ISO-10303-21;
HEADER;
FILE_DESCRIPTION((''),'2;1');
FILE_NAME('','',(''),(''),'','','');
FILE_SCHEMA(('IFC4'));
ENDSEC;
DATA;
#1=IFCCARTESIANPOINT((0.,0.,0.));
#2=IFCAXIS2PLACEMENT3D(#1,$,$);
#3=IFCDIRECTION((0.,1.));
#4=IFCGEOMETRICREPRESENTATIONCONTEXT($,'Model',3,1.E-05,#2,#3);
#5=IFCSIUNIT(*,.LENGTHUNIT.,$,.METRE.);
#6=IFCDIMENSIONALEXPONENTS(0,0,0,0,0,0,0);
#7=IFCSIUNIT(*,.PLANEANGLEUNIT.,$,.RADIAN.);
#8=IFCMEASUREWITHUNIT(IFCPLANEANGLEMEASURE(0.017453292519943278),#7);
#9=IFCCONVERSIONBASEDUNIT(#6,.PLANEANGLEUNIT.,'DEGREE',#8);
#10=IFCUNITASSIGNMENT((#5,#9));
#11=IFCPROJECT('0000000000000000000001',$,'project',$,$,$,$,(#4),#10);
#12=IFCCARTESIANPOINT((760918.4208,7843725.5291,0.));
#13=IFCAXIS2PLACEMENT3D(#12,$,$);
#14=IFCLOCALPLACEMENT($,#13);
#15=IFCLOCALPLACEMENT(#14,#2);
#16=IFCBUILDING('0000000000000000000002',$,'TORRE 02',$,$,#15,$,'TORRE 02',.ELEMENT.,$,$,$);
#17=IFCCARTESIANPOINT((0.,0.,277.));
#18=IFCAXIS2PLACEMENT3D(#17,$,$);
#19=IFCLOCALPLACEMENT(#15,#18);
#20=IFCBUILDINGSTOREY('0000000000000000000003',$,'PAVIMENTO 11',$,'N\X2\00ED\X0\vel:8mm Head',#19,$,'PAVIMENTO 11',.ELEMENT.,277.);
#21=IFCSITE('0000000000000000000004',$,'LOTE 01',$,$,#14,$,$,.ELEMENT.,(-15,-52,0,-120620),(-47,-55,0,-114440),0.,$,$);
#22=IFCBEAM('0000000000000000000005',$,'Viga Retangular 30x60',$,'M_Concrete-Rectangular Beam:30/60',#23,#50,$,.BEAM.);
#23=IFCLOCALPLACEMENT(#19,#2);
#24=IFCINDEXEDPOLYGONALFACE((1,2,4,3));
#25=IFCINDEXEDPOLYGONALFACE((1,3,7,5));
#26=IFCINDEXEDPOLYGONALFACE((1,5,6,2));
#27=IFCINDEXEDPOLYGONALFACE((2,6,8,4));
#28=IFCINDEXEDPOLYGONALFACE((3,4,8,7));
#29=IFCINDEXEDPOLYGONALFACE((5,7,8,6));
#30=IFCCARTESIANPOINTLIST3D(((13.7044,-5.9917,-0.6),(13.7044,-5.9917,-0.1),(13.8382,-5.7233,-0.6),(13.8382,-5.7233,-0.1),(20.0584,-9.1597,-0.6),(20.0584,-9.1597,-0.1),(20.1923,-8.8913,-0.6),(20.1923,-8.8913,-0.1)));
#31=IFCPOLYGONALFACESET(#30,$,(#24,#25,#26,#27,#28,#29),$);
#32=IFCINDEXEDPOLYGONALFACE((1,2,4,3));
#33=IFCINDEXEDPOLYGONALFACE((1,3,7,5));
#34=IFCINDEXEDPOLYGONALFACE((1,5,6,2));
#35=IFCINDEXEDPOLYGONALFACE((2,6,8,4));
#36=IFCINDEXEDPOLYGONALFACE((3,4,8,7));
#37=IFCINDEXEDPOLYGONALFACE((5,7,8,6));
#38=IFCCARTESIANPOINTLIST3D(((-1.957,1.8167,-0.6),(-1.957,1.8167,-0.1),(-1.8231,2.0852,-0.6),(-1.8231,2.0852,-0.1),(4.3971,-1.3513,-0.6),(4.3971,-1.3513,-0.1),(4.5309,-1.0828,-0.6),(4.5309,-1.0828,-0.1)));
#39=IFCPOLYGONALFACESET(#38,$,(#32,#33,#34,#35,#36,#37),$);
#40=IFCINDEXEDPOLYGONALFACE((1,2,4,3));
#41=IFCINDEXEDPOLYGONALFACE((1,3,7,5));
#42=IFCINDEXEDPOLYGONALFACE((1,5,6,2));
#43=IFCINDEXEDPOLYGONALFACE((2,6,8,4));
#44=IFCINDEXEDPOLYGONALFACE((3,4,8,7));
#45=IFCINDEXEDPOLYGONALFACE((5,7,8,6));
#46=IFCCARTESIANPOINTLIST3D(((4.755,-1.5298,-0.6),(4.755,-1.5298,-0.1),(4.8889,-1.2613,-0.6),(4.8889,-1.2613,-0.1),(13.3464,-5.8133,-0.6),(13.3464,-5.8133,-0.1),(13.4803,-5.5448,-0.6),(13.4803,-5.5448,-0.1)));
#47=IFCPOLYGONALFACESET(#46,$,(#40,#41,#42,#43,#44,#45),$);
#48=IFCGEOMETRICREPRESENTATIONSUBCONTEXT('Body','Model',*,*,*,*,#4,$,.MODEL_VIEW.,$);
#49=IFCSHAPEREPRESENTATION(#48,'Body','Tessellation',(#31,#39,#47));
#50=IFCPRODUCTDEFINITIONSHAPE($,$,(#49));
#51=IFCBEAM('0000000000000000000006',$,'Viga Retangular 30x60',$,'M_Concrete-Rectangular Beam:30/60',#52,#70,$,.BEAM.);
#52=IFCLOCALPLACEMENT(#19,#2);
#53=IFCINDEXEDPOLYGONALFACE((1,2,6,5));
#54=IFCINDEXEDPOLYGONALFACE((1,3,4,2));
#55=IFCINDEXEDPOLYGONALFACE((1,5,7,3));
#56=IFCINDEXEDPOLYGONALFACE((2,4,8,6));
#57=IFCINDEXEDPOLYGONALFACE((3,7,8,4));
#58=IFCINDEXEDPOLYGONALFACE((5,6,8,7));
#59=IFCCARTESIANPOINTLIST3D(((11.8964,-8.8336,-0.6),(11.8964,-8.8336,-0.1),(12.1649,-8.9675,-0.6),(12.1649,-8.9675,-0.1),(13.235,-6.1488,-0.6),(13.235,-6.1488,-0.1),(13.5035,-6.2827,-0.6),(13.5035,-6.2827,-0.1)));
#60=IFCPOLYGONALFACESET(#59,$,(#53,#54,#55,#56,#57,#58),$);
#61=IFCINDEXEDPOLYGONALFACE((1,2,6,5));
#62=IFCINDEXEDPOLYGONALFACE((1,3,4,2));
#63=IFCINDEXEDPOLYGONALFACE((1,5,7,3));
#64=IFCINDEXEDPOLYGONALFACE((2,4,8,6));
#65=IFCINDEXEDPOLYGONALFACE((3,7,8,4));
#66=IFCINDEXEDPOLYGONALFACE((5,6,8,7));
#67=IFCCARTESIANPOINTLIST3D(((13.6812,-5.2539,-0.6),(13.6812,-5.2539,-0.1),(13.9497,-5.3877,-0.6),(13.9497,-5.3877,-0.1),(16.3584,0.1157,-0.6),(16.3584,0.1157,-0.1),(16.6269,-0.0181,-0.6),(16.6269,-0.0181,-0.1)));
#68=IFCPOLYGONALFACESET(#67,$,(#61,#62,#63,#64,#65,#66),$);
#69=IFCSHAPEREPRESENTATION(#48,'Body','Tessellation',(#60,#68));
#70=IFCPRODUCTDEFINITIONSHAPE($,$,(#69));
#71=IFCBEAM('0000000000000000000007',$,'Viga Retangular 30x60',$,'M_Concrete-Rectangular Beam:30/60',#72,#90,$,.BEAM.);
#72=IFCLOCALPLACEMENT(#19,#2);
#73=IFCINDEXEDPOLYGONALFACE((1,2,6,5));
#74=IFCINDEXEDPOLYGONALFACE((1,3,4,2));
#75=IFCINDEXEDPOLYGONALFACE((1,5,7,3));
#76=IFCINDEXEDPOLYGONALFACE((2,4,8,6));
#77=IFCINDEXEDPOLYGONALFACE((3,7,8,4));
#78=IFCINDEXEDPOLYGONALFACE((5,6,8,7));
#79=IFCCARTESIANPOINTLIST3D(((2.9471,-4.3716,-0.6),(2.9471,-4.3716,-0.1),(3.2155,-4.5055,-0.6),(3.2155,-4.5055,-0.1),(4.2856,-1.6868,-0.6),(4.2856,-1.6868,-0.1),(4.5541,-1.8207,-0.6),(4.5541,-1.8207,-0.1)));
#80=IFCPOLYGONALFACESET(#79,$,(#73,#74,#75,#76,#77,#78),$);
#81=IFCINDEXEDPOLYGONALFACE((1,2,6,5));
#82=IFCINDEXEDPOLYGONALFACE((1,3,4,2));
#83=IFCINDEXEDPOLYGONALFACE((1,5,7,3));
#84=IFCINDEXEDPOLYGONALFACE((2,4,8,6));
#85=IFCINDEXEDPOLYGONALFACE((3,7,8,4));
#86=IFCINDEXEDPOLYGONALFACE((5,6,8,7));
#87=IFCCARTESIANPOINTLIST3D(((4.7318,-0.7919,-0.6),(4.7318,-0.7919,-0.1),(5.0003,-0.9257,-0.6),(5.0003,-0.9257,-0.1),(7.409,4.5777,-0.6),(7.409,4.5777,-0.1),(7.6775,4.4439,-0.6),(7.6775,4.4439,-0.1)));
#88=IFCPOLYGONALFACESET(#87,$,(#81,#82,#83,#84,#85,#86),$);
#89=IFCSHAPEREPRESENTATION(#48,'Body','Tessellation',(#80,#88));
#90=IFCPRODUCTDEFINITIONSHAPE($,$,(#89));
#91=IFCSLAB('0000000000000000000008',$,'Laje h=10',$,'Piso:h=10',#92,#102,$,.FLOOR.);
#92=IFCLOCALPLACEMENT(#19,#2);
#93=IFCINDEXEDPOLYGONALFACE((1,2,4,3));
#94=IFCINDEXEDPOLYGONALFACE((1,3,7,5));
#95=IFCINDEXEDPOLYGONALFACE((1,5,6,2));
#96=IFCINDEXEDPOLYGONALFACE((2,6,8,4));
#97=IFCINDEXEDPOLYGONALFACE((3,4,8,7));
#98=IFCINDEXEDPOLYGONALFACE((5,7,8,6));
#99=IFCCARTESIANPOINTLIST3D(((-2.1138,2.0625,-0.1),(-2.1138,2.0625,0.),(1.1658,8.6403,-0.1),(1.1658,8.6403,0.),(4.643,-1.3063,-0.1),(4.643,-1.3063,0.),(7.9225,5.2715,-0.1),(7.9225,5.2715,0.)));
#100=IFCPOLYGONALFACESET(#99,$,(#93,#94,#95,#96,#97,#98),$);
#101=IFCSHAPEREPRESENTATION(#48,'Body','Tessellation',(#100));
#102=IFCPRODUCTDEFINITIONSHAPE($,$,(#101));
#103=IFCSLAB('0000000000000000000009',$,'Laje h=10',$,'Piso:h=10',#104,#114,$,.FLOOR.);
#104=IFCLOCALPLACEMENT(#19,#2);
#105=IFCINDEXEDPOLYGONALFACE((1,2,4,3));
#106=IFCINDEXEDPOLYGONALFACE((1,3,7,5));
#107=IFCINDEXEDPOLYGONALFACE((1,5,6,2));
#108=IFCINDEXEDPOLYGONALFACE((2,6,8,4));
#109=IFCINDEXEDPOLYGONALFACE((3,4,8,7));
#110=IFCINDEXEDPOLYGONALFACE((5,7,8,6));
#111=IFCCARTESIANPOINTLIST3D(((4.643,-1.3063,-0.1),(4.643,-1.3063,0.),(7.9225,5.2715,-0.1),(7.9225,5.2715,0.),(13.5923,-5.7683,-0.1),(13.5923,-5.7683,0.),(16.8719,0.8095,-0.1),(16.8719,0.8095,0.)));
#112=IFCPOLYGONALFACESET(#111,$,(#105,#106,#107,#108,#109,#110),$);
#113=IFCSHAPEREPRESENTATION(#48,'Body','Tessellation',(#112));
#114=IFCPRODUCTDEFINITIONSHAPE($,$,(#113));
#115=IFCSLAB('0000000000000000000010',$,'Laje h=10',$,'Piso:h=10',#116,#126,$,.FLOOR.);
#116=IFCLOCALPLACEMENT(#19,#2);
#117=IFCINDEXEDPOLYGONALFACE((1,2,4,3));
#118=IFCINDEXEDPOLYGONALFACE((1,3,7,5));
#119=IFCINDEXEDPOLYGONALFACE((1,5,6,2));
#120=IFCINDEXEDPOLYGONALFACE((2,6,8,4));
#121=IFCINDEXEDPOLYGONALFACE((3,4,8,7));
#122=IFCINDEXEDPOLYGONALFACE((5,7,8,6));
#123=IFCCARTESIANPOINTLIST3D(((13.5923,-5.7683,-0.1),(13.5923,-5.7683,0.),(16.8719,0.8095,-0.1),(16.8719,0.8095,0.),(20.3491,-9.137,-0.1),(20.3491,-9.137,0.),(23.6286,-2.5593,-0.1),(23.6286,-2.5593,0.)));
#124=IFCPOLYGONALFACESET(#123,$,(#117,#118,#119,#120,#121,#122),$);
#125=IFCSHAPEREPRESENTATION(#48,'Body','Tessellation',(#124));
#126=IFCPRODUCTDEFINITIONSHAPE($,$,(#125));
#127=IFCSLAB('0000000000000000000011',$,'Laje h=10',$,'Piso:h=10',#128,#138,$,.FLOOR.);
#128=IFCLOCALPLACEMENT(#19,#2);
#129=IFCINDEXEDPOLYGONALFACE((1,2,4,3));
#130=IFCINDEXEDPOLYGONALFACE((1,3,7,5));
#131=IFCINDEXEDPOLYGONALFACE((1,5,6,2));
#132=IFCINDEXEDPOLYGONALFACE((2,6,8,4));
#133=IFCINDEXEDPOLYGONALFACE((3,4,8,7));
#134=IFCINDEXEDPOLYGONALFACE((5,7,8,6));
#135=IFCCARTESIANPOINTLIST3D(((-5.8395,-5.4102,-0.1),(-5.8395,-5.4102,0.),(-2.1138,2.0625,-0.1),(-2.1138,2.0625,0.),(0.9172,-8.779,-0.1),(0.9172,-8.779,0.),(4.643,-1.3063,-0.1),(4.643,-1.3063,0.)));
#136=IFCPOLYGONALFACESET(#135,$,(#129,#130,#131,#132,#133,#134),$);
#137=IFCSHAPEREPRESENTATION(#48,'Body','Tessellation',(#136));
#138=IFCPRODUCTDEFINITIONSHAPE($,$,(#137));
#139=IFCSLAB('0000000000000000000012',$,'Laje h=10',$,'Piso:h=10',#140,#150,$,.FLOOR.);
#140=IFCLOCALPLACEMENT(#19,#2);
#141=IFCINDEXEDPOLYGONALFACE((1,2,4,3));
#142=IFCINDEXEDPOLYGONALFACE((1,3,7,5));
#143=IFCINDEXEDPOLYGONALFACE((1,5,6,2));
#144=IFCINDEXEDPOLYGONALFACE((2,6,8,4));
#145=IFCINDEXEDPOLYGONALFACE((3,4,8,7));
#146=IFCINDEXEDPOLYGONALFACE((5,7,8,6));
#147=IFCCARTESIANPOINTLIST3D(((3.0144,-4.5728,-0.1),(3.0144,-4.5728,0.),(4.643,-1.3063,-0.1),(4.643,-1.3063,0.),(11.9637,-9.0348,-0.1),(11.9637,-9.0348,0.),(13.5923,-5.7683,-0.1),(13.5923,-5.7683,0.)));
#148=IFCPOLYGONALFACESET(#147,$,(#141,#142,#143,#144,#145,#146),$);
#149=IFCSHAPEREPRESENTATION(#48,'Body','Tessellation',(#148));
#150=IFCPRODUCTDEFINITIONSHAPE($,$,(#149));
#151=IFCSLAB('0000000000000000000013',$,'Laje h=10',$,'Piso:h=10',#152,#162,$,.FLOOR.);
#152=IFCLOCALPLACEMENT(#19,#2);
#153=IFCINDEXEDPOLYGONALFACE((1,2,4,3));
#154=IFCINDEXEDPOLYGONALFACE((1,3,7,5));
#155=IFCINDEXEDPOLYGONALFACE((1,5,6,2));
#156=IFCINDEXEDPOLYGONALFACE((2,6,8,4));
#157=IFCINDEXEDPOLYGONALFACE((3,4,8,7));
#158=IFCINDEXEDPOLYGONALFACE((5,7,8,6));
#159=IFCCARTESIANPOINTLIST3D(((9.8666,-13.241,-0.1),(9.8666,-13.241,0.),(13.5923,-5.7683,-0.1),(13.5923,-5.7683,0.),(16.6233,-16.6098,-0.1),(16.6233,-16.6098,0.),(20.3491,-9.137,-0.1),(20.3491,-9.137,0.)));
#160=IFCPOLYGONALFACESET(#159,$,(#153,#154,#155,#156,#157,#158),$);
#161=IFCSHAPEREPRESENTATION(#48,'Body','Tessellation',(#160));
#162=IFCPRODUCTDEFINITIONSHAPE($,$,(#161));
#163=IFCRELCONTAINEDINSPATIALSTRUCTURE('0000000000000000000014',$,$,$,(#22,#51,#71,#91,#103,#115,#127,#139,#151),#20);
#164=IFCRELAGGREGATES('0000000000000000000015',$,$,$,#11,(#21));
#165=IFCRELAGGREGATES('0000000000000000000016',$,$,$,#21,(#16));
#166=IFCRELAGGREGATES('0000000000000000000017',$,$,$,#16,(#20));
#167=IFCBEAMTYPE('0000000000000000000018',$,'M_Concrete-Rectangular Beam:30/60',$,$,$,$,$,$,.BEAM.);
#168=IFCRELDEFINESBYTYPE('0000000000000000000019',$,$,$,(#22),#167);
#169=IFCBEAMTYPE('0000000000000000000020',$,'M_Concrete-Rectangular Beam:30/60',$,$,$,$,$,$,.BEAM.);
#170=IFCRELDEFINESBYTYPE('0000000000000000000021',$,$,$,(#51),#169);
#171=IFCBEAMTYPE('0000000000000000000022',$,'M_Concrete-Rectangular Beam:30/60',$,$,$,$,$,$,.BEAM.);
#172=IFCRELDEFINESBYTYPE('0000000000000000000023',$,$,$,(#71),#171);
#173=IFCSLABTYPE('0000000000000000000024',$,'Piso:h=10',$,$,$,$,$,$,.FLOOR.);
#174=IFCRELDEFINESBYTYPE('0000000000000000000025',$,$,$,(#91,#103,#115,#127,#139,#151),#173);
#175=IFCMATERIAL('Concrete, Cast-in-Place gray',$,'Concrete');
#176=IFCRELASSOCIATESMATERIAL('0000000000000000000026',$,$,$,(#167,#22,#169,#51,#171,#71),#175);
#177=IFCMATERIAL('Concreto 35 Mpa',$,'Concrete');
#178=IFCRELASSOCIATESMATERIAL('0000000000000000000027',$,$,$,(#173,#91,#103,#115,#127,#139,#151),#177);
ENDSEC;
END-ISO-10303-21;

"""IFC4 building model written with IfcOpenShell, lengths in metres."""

from ifc_helpers import new_model, entity, si_unit, converted_unit, direction, frame, origin, place, context, subcontext, project, spatial, indexed_curve, outline, extrude, source, transform, mapped, material, type_object, type_shapes, element, save


model = new_model("IFC4")

# Units and contexts
model_context = context("Model", 3, precision=1e-05, world=origin(), true_north=direction((0.0, 1.0)))
body_context = subcontext(model_context, "Body", "Model", "MODEL_VIEW")
ifc_project = project(units=[si_unit("LENGTHUNIT", "METRE"), converted_unit("PLANEANGLEUNIT", "DEGREE", entity("IfcPlaneAngleMeasure", 0.017453292519943278), si_unit("PLANEANGLEUNIT", "RADIAN"), dimensions=[0, 0, 0, 0, 0, 0, 0])], contexts=[model_context])

# Site, building, storey
site_placement = place(None, frame((760918.4208, 7843725.5291, 0.0)))
site = spatial("IfcSite", under=ifc_project, at=site_placement, Name="LOTE 01", CompositionType="ELEMENT", RefLatitude=(-15, -52, 0, -120620), RefLongitude=(-47, -55, 0, -114440), RefElevation=0.0)
building_placement = place(site_placement, origin())
building = spatial("IfcBuilding", under=site, at=building_placement, Name="TORRE 02", LongName="TORRE 02", CompositionType="ELEMENT")
storey_placement = place(building_placement, frame((0.0, 0.0, 277.0)))
storey = spatial("IfcBuildingStorey", under=building, at=storey_placement, Name="PAVIMENTO 11", ObjectType="Nível:8mm Head", LongName="PAVIMENTO 11", CompositionType="ELEMENT", Elevation=277.0)

# Shared definitions
ifc_material_1 = material(Name="Concrete, Cast-in-Place gray", Category="Concrete")

# Beams
beam_type_1 = type_object("IfcBeamType", Name="M_Concrete-Rectangular Beam:30/60", PredefinedType="BEAM", material=ifc_material_1)
shared_shape_1 = source(origin(), body_context, "Body", "SweptSolid", [
    extrude(outline(indexed_curve([(-0.25, -0.15), (0.25, -0.15), (0.25, 0.15), (-0.25, 0.15), (-0.25, -0.15)], self_intersect=False)), frame((13.7713, -5.8575, 276.65), z_axis=(0.894934, -0.446198, 0.0), x_axis=(0.0, 0.0, -1.0)), (0.0, 0.0, 1.0), 7.1),
    extrude(outline(indexed_curve([(-0.25, -0.15), (0.25, -0.15), (0.25, 0.15), (-0.25, 0.15), (-0.25, -0.15)], self_intersect=False)), frame((-1.89, 1.951, 276.65), z_axis=(0.894934, -0.446198, 0.0), x_axis=(0.0, 0.0, -1.0)), (0.0, 0.0, 1.0), 7.1),
    extrude(outline(indexed_curve([(-0.25, -0.15), (0.25, -0.15), (0.25, 0.15), (-0.25, 0.15), (-0.25, -0.15)], self_intersect=False)), frame((4.822, -1.3955, 276.65), z_axis=(0.894934, -0.446198, 0.0), x_axis=(0.0, 0.0, -1.0)), (0.0, 0.0, 1.0), 9.6),
])
type_shapes(beam_type_1, [shared_shape_1])
beam_1_placement = place(storey_placement, frame((0.0, 0.0, -277.0)))
element("IfcBeam", 1, at=beam_1_placement, inside=storey, type_object=beam_type_1, material=ifc_material_1, Name="Viga Retangular 30x60", ObjectType="M_Concrete-Rectangular Beam:30/60", PredefinedType="BEAM", context=body_context, shape_type="MappedRepresentation", body=[
    mapped(shared_shape_1, transform((0.0, 0.0, 0.0), scale=1.0)),
])
beam_type_2 = type_object("IfcBeamType", Name="M_Concrete-Rectangular Beam:30/60", PredefinedType="BEAM", material=ifc_material_1)
shared_shape_2 = source(origin(), body_context, "Body", "SweptSolid", [
    extrude(outline(indexed_curve([(-0.25, -0.15), (0.25, -0.15), (0.25, 0.15), (-0.25, 0.15), (-0.25, -0.15)], self_intersect=False)), frame((12.0306, -8.9005, 276.65), z_axis=(0.446198, 0.894934, 0.0), x_axis=(0.0, 0.0, 1.0)), (0.0, 0.0, 1.0), 3.0),
    extrude(outline(indexed_curve([(-0.25, -0.15), (0.25, -0.15), (0.25, 0.15), (-0.25, 0.15), (-0.25, -0.15)], self_intersect=False)), frame((13.8154, -5.3208, 276.65), z_axis=(0.446198, 0.894934, 0.0), x_axis=(0.0, 0.0, 1.0)), (0.0, 0.0, 1.0), 6.0),
])
type_shapes(beam_type_2, [shared_shape_2])
beam_2_placement = place(storey_placement, frame((0.0, 0.0, -277.0)))
element("IfcBeam", 2, at=beam_2_placement, inside=storey, type_object=beam_type_2, material=ifc_material_1, Name="Viga Retangular 30x60", ObjectType="M_Concrete-Rectangular Beam:30/60", PredefinedType="BEAM", context=body_context, shape_type="MappedRepresentation", body=[
    mapped(shared_shape_2, transform((0.0, 0.0, 0.0), scale=1.0)),
])
beam_type_3 = type_object("IfcBeamType", Name="M_Concrete-Rectangular Beam:30/60", PredefinedType="BEAM", material=ifc_material_1)
shared_shape_3 = source(origin(), body_context, "Body", "SweptSolid", [
    extrude(outline(indexed_curve([(-0.25, -0.15), (0.25, -0.15), (0.25, 0.15), (-0.25, 0.15), (-0.25, -0.15)], self_intersect=False)), frame((3.0813, -4.4385, 276.65), z_axis=(0.446198, 0.894934, 0.0), x_axis=(0.0, 0.0, 1.0)), (0.0, 0.0, 1.0), 3.0),
    extrude(outline(indexed_curve([(-0.25, -0.15), (0.25, -0.15), (0.25, 0.15), (-0.25, 0.15), (-0.25, -0.15)], self_intersect=False)), frame((4.8661, -0.8588, 276.65), z_axis=(0.446198, 0.894934, 0.0), x_axis=(0.0, 0.0, 1.0)), (0.0, 0.0, 1.0), 6.0),
])
type_shapes(beam_type_3, [shared_shape_3])
beam_3_placement = place(storey_placement, frame((0.0, 0.0, -277.0)))
element("IfcBeam", 3, at=beam_3_placement, inside=storey, type_object=beam_type_3, material=ifc_material_1, Name="Viga Retangular 30x60", ObjectType="M_Concrete-Rectangular Beam:30/60", PredefinedType="BEAM", context=body_context, shape_type="MappedRepresentation", body=[
    mapped(shared_shape_3, transform((0.0, 0.0, 0.0), scale=1.0)),
])

# Slabs
ifc_material_2 = material(Name="Concreto 35 Mpa", Category="Concrete")
slab_type = type_object("IfcSlabType", Name="Piso:h=10", PredefinedType="FLOOR", material=ifc_material_2)
slab_1_placement = place(storey_placement, origin())
element("IfcSlab", 4, at=slab_1_placement, inside=storey, type_object=slab_type, material=ifc_material_2, Name="Laje h=10", ObjectType="Piso:h=10", PredefinedType="FLOOR", context=body_context, shape_type="SweptSolid", body=[
    extrude(outline(indexed_curve([(-3.675, -3.775), (3.675, -3.775), (3.675, 3.775), (-3.675, 3.775), (-3.675, -3.775)], self_intersect=False)), frame((2.9044, 3.667, 0.0), z_axis=(0.0, 0.0, -1.0), x_axis=(-0.446198, -0.894934, 0.0)), (0.0, 0.0, 1.0), 0.1),
])
slab_2_placement = place(storey_placement, origin())
element("IfcSlab", 5, at=slab_2_placement, inside=storey, type_object=slab_type, material=ifc_material_2, Name="Laje h=10", ObjectType="Piso:h=10", PredefinedType="FLOOR", context=body_context, shape_type="SweptSolid", body=[
    extrude(outline(indexed_curve([(-3.675, -5.0), (3.675, -5.0), (3.675, 5.0), (-3.675, 5.0), (-3.675, -5.0)], self_intersect=False)), frame((10.7574, -0.2484, 0.0), z_axis=(0.0, 0.0, -1.0), x_axis=(-0.446198, -0.894934, 0.0)), (0.0, 0.0, 1.0), 0.1),
])
slab_3_placement = place(storey_placement, origin())
element("IfcSlab", 6, at=slab_3_placement, inside=storey, type_object=slab_type, material=ifc_material_2, Name="Laje h=10", ObjectType="Piso:h=10", PredefinedType="FLOOR", context=body_context, shape_type="SweptSolid", body=[
    extrude(outline(indexed_curve([(-3.675, -3.775), (3.675, -3.775), (3.675, 3.775), (-3.675, 3.775), (-3.675, -3.775)], self_intersect=False)), frame((18.6105, -4.1638, 0.0), z_axis=(0.0, 0.0, -1.0), x_axis=(-0.446198, -0.894934, 0.0)), (0.0, 0.0, 1.0), 0.1),
])
slab_4_placement = place(storey_placement, origin())
element("IfcSlab", 7, at=slab_4_placement, inside=storey, type_object=slab_type, material=ifc_material_2, Name="Laje h=10", ObjectType="Piso:h=10", PredefinedType="FLOOR", context=body_context, shape_type="SweptSolid", body=[
    extrude(outline(indexed_curve([(-4.175, -3.775), (4.175, -3.775), (4.175, 3.775), (-4.175, 3.775), (-4.175, -3.775)], self_intersect=False)), frame((-0.5983, -3.3582, 0.0), z_axis=(0.0, 0.0, -1.0), x_axis=(-0.446198, -0.894934, 0.0)), (0.0, 0.0, 1.0), 0.1),
])
slab_5_placement = place(storey_placement, origin())
element("IfcSlab", 8, at=slab_5_placement, inside=storey, type_object=slab_type, material=ifc_material_2, Name="Laje h=10", ObjectType="Piso:h=10", PredefinedType="FLOOR", context=body_context, shape_type="SweptSolid", body=[
    extrude(outline(indexed_curve([(-1.825, -5.0), (1.825, -5.0), (1.825, 5.0), (-1.825, 5.0), (-1.825, -5.0)], self_intersect=False)), frame((8.3033, -5.1705, 0.0), z_axis=(0.0, 0.0, -1.0), x_axis=(-0.446198, -0.894934, 0.0)), (0.0, 0.0, 1.0), 0.1),
])
slab_6_placement = place(storey_placement, origin())
element("IfcSlab", 9, at=slab_6_placement, inside=storey, type_object=slab_type, material=ifc_material_2, Name="Laje h=10", ObjectType="Piso:h=10", PredefinedType="FLOOR", context=body_context, shape_type="SweptSolid", body=[
    extrude(outline(indexed_curve([(-4.175, -3.775), (4.175, -3.775), (4.175, 3.775), (-4.175, 3.775), (-4.175, -3.775)], self_intersect=False)), frame((15.1078, -11.189, 0.0), z_axis=(0.0, 0.0, -1.0), x_axis=(-0.446198, -0.894934, 0.0)), (0.0, 0.0, 1.0), 0.1),
])

save(model, "model.ifc")
